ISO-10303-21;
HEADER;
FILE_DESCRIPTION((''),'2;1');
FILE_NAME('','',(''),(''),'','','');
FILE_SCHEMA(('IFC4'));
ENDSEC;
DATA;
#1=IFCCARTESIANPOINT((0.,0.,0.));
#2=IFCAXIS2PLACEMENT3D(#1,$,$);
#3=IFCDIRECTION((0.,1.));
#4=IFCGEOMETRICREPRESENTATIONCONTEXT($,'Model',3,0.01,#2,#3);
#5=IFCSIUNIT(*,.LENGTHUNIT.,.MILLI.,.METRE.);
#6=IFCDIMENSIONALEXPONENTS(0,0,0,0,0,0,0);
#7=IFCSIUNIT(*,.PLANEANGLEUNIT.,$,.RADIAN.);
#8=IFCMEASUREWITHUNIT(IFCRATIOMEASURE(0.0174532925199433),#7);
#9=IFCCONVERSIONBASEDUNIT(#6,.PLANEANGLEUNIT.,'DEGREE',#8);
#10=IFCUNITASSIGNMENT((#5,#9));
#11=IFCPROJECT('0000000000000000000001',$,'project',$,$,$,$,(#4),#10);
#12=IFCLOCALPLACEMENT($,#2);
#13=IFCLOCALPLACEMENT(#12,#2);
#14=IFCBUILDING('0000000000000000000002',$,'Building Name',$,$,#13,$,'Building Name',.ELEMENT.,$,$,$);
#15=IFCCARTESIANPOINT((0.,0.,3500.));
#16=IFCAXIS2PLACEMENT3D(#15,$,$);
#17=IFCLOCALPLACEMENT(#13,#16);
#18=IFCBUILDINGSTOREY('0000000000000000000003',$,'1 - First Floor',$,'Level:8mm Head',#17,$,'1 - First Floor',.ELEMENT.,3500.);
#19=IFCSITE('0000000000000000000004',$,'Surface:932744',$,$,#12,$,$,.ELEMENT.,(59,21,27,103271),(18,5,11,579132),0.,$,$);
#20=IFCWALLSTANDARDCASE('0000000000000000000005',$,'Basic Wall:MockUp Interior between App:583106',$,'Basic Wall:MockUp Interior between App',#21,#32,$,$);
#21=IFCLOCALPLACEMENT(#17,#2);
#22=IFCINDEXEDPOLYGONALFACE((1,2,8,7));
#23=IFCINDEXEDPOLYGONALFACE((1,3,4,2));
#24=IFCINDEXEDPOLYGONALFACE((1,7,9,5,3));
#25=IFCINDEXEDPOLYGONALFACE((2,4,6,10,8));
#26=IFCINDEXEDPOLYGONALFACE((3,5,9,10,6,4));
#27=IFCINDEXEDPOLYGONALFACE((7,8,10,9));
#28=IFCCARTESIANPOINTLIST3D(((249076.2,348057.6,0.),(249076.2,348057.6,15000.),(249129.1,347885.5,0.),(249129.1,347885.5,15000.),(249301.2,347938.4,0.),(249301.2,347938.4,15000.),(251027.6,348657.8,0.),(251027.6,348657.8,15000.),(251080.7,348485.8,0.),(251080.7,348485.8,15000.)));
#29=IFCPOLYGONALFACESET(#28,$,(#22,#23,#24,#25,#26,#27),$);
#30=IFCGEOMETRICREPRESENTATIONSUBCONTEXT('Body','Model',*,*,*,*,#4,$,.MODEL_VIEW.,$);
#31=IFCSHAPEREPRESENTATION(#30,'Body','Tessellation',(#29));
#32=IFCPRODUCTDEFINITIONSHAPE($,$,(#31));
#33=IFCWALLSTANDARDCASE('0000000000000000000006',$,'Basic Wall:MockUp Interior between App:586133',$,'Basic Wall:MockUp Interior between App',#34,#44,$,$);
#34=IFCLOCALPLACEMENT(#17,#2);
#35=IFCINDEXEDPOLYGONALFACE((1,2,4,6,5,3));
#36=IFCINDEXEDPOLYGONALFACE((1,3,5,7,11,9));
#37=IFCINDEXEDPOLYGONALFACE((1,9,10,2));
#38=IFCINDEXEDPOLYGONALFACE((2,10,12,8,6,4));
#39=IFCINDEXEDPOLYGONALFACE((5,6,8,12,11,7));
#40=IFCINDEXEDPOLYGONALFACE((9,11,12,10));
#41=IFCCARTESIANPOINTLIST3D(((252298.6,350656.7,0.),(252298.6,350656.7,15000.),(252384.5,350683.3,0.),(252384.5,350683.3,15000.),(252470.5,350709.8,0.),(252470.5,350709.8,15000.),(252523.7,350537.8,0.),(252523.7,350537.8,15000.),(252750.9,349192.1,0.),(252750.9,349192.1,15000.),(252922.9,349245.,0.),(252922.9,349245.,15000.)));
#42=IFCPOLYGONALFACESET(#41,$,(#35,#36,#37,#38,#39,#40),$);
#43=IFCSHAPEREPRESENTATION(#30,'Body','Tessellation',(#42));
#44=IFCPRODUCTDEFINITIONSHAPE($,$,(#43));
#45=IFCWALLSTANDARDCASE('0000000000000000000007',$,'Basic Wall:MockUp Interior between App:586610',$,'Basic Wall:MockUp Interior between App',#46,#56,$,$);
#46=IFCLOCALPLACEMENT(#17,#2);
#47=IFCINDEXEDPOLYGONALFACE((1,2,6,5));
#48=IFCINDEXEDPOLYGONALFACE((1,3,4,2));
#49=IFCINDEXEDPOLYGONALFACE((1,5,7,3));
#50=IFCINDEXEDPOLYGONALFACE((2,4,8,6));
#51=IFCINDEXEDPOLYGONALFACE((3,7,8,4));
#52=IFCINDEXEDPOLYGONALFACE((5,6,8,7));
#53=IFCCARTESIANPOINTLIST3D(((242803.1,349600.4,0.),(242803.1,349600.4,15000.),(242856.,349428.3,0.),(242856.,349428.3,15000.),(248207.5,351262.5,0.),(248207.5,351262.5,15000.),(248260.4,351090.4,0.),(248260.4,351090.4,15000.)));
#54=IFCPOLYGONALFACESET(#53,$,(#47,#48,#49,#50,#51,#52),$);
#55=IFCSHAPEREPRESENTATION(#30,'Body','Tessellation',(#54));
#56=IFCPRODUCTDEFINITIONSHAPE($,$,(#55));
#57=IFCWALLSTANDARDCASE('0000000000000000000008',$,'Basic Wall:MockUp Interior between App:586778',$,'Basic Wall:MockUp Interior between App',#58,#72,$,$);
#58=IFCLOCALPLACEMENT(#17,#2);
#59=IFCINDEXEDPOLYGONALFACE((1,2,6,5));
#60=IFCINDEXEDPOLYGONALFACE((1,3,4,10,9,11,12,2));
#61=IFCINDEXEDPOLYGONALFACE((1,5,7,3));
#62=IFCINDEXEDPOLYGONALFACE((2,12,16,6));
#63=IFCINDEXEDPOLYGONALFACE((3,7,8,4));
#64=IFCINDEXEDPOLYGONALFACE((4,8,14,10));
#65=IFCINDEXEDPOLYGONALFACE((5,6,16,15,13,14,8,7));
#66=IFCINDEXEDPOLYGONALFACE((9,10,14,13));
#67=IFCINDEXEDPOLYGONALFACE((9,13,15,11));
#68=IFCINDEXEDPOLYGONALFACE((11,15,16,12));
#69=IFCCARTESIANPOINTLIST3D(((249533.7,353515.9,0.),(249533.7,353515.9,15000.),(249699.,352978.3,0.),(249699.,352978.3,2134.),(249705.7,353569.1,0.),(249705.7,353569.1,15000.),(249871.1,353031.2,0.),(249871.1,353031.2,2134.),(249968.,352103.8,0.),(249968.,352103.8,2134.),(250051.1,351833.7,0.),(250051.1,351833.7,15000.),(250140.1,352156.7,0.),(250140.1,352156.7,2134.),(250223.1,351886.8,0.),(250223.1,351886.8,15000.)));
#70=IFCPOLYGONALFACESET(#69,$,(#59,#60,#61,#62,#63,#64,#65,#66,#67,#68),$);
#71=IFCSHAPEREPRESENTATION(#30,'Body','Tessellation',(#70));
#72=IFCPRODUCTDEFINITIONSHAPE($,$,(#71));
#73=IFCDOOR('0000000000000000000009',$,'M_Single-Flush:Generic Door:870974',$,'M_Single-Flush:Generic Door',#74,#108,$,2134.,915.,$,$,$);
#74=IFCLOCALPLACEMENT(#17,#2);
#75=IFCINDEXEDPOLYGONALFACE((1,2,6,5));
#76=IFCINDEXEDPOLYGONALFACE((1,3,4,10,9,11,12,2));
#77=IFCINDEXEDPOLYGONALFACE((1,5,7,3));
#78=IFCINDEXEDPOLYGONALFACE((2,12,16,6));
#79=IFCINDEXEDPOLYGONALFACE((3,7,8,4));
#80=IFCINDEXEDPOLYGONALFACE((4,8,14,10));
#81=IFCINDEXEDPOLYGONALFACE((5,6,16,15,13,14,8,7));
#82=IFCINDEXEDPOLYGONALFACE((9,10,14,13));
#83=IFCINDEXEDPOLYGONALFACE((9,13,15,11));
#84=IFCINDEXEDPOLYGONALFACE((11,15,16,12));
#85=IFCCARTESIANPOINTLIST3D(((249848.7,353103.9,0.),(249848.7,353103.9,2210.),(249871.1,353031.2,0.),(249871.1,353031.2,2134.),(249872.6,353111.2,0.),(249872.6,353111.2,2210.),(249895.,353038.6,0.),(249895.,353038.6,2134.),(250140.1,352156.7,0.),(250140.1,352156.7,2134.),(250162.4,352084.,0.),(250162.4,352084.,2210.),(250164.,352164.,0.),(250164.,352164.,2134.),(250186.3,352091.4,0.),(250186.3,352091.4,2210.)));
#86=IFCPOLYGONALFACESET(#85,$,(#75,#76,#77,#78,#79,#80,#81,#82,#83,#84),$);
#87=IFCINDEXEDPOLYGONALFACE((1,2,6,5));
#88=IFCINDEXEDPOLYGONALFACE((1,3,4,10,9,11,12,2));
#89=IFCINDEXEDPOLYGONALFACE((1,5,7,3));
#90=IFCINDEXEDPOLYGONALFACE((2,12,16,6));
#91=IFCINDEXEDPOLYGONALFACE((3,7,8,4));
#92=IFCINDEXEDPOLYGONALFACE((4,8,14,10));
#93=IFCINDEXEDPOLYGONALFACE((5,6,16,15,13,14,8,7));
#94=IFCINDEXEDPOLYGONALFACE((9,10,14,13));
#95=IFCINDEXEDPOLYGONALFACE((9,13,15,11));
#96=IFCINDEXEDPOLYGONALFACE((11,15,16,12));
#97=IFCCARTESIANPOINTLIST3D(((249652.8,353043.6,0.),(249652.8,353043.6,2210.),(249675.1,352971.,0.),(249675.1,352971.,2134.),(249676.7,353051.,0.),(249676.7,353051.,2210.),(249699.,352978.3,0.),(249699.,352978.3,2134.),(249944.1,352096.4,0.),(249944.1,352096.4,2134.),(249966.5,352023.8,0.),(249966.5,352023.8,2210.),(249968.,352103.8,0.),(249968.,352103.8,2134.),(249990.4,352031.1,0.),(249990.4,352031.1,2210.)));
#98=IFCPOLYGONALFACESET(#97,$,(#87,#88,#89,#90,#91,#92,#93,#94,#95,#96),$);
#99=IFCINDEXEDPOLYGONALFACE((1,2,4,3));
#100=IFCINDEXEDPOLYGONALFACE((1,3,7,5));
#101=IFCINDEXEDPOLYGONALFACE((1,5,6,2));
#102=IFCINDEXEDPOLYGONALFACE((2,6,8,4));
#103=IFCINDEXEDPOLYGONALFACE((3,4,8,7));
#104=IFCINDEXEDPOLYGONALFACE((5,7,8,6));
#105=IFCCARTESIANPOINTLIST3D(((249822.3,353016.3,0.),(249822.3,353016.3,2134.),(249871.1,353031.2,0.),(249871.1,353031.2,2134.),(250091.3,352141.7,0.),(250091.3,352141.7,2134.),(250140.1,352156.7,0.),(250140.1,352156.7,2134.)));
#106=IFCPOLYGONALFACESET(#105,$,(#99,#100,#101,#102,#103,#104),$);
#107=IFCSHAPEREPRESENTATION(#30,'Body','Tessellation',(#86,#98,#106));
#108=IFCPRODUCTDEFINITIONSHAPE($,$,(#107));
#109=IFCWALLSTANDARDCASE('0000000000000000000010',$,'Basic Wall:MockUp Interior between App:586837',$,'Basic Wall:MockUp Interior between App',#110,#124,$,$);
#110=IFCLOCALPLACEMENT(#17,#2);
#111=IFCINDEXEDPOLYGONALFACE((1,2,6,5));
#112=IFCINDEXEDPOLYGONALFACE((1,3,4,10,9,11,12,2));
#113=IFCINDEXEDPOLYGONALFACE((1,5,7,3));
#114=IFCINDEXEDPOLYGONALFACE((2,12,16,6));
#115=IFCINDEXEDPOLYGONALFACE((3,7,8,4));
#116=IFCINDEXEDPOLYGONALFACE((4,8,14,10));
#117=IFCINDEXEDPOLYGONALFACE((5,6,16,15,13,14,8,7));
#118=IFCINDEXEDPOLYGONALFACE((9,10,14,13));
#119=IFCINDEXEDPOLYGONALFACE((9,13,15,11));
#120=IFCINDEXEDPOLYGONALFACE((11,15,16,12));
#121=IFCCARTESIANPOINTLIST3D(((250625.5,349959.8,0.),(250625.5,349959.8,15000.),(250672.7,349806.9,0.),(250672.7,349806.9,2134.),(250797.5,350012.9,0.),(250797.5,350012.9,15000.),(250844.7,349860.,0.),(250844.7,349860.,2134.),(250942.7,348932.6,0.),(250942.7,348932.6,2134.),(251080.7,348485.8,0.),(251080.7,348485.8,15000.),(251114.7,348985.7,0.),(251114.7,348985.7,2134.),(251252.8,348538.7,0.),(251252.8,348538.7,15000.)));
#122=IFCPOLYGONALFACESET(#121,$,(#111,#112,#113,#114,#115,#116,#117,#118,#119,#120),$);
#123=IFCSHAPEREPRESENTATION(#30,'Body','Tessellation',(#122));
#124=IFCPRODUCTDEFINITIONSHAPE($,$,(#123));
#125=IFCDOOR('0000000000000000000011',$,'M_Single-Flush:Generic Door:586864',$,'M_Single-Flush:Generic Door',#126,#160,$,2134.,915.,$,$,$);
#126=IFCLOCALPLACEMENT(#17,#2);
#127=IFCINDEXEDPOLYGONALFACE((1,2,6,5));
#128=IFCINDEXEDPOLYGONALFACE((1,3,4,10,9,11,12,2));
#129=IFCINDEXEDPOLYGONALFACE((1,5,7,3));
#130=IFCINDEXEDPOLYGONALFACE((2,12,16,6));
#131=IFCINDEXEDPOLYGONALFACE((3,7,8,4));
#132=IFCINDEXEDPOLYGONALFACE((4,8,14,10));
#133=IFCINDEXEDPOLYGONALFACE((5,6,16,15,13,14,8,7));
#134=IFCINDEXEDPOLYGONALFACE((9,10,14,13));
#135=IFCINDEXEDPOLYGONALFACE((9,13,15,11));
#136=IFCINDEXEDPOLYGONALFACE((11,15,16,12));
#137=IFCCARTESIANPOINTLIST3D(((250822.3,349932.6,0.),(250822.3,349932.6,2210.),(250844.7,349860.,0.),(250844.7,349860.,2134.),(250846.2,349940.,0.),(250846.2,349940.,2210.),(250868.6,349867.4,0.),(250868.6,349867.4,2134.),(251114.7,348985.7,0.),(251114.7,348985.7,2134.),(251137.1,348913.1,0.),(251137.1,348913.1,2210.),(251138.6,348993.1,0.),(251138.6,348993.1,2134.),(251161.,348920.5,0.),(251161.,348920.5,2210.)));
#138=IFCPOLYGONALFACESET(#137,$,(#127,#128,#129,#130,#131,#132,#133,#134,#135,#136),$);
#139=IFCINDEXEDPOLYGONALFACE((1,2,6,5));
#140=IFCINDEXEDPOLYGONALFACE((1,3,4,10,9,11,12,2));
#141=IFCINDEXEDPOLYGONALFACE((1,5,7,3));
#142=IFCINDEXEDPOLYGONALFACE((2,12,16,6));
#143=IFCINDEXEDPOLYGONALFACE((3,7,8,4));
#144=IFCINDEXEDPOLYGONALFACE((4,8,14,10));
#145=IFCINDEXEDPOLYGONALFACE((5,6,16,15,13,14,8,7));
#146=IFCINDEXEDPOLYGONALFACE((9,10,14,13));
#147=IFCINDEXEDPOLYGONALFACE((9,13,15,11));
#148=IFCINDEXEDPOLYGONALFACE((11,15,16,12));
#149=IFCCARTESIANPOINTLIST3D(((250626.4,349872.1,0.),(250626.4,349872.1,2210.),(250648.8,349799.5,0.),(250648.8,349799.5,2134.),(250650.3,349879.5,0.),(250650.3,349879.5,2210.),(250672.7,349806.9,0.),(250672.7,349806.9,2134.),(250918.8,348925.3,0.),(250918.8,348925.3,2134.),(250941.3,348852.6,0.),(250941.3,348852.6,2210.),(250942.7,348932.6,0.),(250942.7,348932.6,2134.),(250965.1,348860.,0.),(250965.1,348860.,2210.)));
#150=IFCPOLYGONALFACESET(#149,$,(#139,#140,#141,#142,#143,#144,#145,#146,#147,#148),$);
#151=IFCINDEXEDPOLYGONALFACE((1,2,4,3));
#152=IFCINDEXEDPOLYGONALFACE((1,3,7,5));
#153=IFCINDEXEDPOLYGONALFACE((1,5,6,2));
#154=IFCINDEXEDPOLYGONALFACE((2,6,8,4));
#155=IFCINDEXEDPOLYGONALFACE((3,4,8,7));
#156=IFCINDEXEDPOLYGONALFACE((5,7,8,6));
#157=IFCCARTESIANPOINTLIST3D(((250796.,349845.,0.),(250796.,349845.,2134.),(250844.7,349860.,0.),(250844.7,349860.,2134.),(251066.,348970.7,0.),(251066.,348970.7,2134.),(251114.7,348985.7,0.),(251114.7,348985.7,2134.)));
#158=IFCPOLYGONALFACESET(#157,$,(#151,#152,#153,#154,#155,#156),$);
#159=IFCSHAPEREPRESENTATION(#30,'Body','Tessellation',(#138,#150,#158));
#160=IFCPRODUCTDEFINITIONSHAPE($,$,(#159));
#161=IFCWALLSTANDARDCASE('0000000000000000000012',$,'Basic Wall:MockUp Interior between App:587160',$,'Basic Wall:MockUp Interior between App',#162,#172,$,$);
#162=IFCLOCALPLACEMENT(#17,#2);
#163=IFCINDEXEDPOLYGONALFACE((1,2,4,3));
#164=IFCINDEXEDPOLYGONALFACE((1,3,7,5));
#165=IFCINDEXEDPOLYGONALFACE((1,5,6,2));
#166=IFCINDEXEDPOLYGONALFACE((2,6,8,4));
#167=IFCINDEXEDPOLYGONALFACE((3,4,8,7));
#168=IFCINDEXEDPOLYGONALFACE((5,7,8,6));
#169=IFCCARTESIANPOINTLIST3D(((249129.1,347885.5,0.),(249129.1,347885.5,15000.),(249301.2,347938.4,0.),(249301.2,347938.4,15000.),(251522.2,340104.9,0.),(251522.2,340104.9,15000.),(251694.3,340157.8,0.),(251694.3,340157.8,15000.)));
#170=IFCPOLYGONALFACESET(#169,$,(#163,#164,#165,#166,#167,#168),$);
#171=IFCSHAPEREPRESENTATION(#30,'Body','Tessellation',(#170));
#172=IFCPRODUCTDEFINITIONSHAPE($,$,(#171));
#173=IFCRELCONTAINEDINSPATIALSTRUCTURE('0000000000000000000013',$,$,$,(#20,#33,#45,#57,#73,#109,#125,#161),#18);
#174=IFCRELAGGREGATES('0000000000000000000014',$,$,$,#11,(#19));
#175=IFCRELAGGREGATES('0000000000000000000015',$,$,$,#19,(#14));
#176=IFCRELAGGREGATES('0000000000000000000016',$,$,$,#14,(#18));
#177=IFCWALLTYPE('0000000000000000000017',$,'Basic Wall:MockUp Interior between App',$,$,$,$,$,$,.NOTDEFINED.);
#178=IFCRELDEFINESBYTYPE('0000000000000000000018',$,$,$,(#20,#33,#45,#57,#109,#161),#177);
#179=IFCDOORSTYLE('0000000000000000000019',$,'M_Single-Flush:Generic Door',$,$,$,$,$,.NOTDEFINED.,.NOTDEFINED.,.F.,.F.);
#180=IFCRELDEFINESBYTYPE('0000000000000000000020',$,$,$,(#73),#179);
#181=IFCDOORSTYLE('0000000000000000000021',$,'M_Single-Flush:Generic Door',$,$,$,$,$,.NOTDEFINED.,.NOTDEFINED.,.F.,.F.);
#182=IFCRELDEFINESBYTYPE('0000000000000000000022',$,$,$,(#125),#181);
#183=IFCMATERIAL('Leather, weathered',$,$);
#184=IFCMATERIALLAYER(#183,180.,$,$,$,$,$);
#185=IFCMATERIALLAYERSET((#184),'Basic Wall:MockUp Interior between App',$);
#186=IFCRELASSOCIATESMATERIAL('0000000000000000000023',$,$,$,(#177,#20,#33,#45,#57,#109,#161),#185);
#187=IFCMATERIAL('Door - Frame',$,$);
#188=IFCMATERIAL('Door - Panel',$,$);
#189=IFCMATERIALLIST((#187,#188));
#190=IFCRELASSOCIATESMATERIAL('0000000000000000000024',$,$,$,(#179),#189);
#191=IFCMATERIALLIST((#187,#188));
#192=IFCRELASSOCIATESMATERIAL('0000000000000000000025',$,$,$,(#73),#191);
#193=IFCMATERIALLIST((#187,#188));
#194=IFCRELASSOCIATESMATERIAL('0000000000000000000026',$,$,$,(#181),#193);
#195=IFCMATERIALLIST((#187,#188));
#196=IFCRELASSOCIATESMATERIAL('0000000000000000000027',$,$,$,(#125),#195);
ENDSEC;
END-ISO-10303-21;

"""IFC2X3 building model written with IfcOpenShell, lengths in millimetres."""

from ifc_helpers import new_model, entity, si_unit, converted_unit, direction, frame, frame_2d, origin, place, context, subcontext, project, spatial, polyline, rectangle, outline, extrude, source, transform, mapped, material, material_list, layer, layer_set, layer_usage, type_object, type_shapes, element, fill, save


model = new_model("IFC2X3")

# Units and contexts
model_context = context("Model", 3, precision=0.01, world=origin(), true_north=direction((0.0, 1.0)))
body_context = subcontext(model_context, "Body", "Model", "MODEL_VIEW")
ifc_project = project(units=[si_unit("LENGTHUNIT", "METRE", prefix="MILLI"), converted_unit("PLANEANGLEUNIT", "DEGREE", entity("IfcRatioMeasure", 0.0174532925199433), si_unit("PLANEANGLEUNIT", "RADIAN"), dimensions=[0, 0, 0, 0, 0, 0, 0])], contexts=[model_context])

# Site, building, storey
site_placement = place(None, origin())
site = spatial("IfcSite", under=ifc_project, at=site_placement, Name="Surface:932744", CompositionType="ELEMENT", RefLatitude=(59, 21, 27, 103271), RefLongitude=(18, 5, 11, 579132), RefElevation=0.0)
building_placement = place(site_placement, origin())
building = spatial("IfcBuilding", under=site, at=building_placement, Name="Building Name", LongName="Building Name", CompositionType="ELEMENT")
storey_placement = place(building_placement, frame((0.0, 0.0, 3500.0)))
storey = spatial("IfcBuildingStorey", under=building, at=storey_placement, Name="1 - First Floor", ObjectType="Level:8mm Head", LongName="1 - First Floor", CompositionType="ELEMENT", Elevation=3500.0)

# Walls
ifc_material_1 = material(Name="Leather, weathered")
ifc_layer_1 = layer(ifc_material_1, 180.0)
ifc_layer_set_1 = layer_set([ifc_layer_1], Name="Basic Wall:MockUp Interior between App")
ifc_layer_usage_1 = layer_usage(ifc_layer_set_1, "AXIS2", "NEGATIVE", 90.0)
wall_type_1 = type_object("IfcWallType", Name="Basic Wall:MockUp Interior between App", PredefinedType="NOTDEFINED", material=ifc_layer_set_1)
wall_1_placement = place(storey_placement, frame((249102.6, 347971.5, 0.0), z_axis=(0.0, 0.0, 1.0), x_axis=(0.955811, 0.29398, 0.0)))
element("IfcWallStandardCase", 1, at=wall_1_placement, inside=storey, type_object=wall_type_1, material=ifc_layer_usage_1, Name="Basic Wall:MockUp Interior between App:583106", ObjectType="Basic Wall:MockUp Interior between App", context=body_context, shape_type="SweptSolid", body=[
    extrude(outline(polyline([(0.0, 90.0), (0.0, -90.0), (180.0, -90.0), (2041.8, -90.0), (2041.6, 90.0), (0.0, 90.0)])), origin(), (0.0, 0.0, 1.0), 15000.0),
])
ifc_layer_usage_2 = layer_usage(ifc_layer_set_1, "AXIS2", "NEGATIVE", 90.0)
wall_2_placement = place(storey_placement, frame((252384.5, 350683.3, 0.0), z_axis=(0.0, 0.0, 1.0), x_axis=(0.29508, -0.955473, 0.0)))
element("IfcWallStandardCase", 2, at=wall_2_placement, inside=storey, type_object=wall_type_1, material=ifc_layer_usage_2, Name="Basic Wall:MockUp Interior between App:586133", ObjectType="Basic Wall:MockUp Interior between App", context=body_context, shape_type="SweptSolid", body=[
    extrude(outline(polyline([(1532.8, -90.0), (1533.1, 90.0), (180.0, 90.0), (0.0, 90.0), (0.0, 0.0), (0.0, -90.0), (1532.8, -90.0)])), origin(), (0.0, 0.0, 1.0), 15000.0),
])
ifc_layer_usage_3 = layer_usage(ifc_layer_set_1, "AXIS2", "NEGATIVE", 90.0)
wall_3_placement = place(storey_placement, frame((248234.0, 351176.5, 0.0), z_axis=(0.0, 0.0, 1.0), x_axis=(-0.955818, -0.293958, 0.0)))
element("IfcWallStandardCase", 3, at=wall_3_placement, inside=storey, type_object=wall_type_1, material=ifc_layer_usage_3, Name="Basic Wall:MockUp Interior between App:586610", ObjectType="Basic Wall:MockUp Interior between App", context=body_context, shape_type="SweptSolid", body=[
    extrude(rectangle(XDim=5654.2, YDim=180.0, at=frame_2d((2827.1, 0.0), x_axis=(-1.0, 0.0))), origin(), (0.0, 0.0, 1.0), 15000.0),
])

# Walls, openings, doors
ifc_layer_usage_4 = layer_usage(ifc_layer_set_1, "AXIS2", "NEGATIVE", 90.0)
wall_4_placement = place(storey_placement, frame((250137.1, 351860.2, 0.0), z_axis=(0.0, 0.0, 1.0), x_axis=(-0.293958, 0.955818, 0.0)))
wall_4 = element("IfcWallStandardCase", 4, at=wall_4_placement, inside=storey, type_object=wall_type_1, material=ifc_layer_usage_4, Name="Basic Wall:MockUp Interior between App:586778", ObjectType="Basic Wall:MockUp Interior between App", context=body_context, shape_type="SweptSolid", body=[
    extrude(outline(polyline([(0.2, -90.0), (1760.2, -90.0), (1760.0, 90.0), (0.0, 90.0), (0.2, -90.0)])), origin(), (0.0, 0.0, 1.0), 15000.0),
])
opening_1_placement = place(wall_4_placement, frame((1197.5, 90.0, 0.0)))
opening_1 = element("IfcOpeningElement", 5, at=opening_1_placement, cuts=wall_4, ObjectType="Opening", context=body_context, shape_type="SweptSolid", body=[
    extrude(rectangle(XDim=915.0, YDim=2134.0, at=frame_2d((1067.0, 457.5), x_axis=(0.0, 1.0))), frame((0.0, 0.0, 0.0), z_axis=(0.0, -1.0, 0.0), x_axis=(0.0, 0.0, 1.0)), (0.0, 0.0, 1.0), 180.0),
])
ifc_material_2 = material(Name="Door - Frame")
ifc_material_3 = material(Name="Door - Panel")
ifc_material_list_1 = material_list([ifc_material_2, ifc_material_3])
ifc_material_list_2 = material_list([ifc_material_2, ifc_material_3])
door_style_1 = type_object("IfcDoorStyle", Name="M_Single-Flush:Generic Door", ConstructionType="NOTDEFINED", OperationType="NOTDEFINED", ParameterTakesPrecedence=False, Sizeable=False, material=ifc_material_list_2)
shared_shape_1 = source(origin(), body_context, "Body", "SweptSolid", [
    extrude(outline(polyline([(-533.5, -1124.0), (533.5, -1124.0), (533.5, 1086.0), (457.5, 1086.0), (457.5, -1048.0), (-457.5, -1048.0), (-457.5, 1086.0), (-533.5, 1086.0), (-533.5, -1124.0)])), frame((457.5, 180.0, 1086.0), z_axis=(0.0, 1.0, 0.0), x_axis=(1.0, 0.0, 0.0)), (0.0, 0.0, 1.0), 25.0),
    extrude(outline(polyline([(-1124.0, -533.5), (1086.0, -533.5), (1086.0, -457.5), (-1048.0, -457.5), (-1048.0, 457.5), (1086.0, 457.5), (1086.0, 533.5), (-1124.0, 533.5), (-1124.0, -533.5)])), frame((457.5, -25.0, 1086.0), z_axis=(0.0, 1.0, 0.0), x_axis=(0.0, 0.0, -1.0)), (0.0, 0.0, 1.0), 25.0),
    extrude(rectangle(XDim=51.0, YDim=915.0, at=frame_2d((0.0, 0.0), x_axis=(1.0, 0.0))), frame((457.5, 154.5, 0.0), z_axis=(0.0, 0.0, 1.0), x_axis=(0.0, 1.0, 0.0)), (0.0, 0.0, 1.0), 2134.0),
])
type_shapes(door_style_1, [shared_shape_1])
door_1_placement = place(opening_1_placement, frame((0.0, 0.0, 0.0), z_axis=(0.0, 0.0, 1.0), x_axis=(-1.0, 0.0, 0.0)))
door_1 = element("IfcDoor", 6, at=door_1_placement, inside=storey, type_object=door_style_1, material=ifc_material_list_1, Name="M_Single-Flush:Generic Door:870974", ObjectType="M_Single-Flush:Generic Door", OverallHeight=2134.0, OverallWidth=915.0, context=body_context, shape_type="MappedRepresentation", body=[
    mapped(shared_shape_1, transform((0.0, 0.0, 0.0), scale=1.0)),
])
fill(opening_1, door_1)
ifc_layer_usage_5 = layer_usage(ifc_layer_set_1, "AXIS2", "NEGATIVE", 90.0)
wall_5_placement = place(storey_placement, frame((250711.5, 349986.3, 0.0), z_axis=(0.0, 0.0, 1.0), x_axis=(0.29508, -0.955473, 0.0)))
wall_5 = element("IfcWallStandardCase", 7, at=wall_5_placement, inside=storey, type_object=wall_type_1, material=ifc_layer_usage_5, Name="Basic Wall:MockUp Interior between App:586837", ObjectType="Basic Wall:MockUp Interior between App", context=body_context, shape_type="SweptSolid", body=[
    extrude(outline(polyline([(0.0, -90.0), (1362.7, -90.0), (1542.7, -90.0), (1542.9, 90.0), (1538.8, 90.0), (1358.8, 90.0), (0.0, 90.0), (0.0, -88.2), (0.0, -90.0)])), origin(), (0.0, 0.0, 1.0), 15000.0),
])
opening_2_placement = place(wall_5_placement, frame((160.0, -90.0, 0.0)))
opening_2 = element("IfcOpeningElement", 8, at=opening_2_placement, cuts=wall_5, ObjectType="Opening", context=body_context, shape_type="SweptSolid", body=[
    extrude(rectangle(XDim=915.0, YDim=2134.0, at=frame_2d((1067.0, 457.5), x_axis=(0.0, -1.0))), frame((0.0, 0.0, 0.0), z_axis=(0.0, 1.0, 0.0), x_axis=(0.0, 0.0, 1.0)), (0.0, 0.0, 1.0), 180.0),
])
ifc_material_list_3 = material_list([ifc_material_2, ifc_material_3])
ifc_material_list_4 = material_list([ifc_material_2, ifc_material_3])
door_style_2 = type_object("IfcDoorStyle", Name="M_Single-Flush:Generic Door", ConstructionType="NOTDEFINED", OperationType="NOTDEFINED", ParameterTakesPrecedence=False, Sizeable=False, material=ifc_material_list_4)
shared_shape_2 = source(origin(), body_context, "Body", "SweptSolid", [
    extrude(outline(polyline([(-533.5, -1124.0), (533.5, -1124.0), (533.5, 1086.0), (457.5, 1086.0), (457.5, -1048.0), (-457.5, -1048.0), (-457.5, 1086.0), (-533.5, 1086.0), (-533.5, -1124.0)])), frame((457.5, 205.0, 1086.0), z_axis=(0.0, -1.0, 0.0), x_axis=(-1.0, 0.0, 0.0)), (0.0, 0.0, 1.0), 25.0),
    extrude(outline(polyline([(-1124.0, -533.5), (1086.0, -533.5), (1086.0, -457.5), (-1048.0, -457.5), (-1048.0, 457.5), (1086.0, 457.5), (1086.0, 533.5), (-1124.0, 533.5), (-1124.0, -533.5)])), frame((457.5, 0.0, 1086.0), z_axis=(0.0, -1.0, 0.0), x_axis=(0.0, 0.0, -1.0)), (0.0, 0.0, 1.0), 25.0),
    extrude(rectangle(XDim=915.0, YDim=51.0, at=frame_2d((0.0, 0.0), x_axis=(1.0, 0.0))), frame((457.5, 154.5, 0.0)), (0.0, 0.0, 1.0), 2134.0),
])
type_shapes(door_style_2, [shared_shape_2])
door_2_placement = place(opening_2_placement, origin())
door_2 = element("IfcDoor", 9, at=door_2_placement, inside=storey, type_object=door_style_2, material=ifc_material_list_3, Name="M_Single-Flush:Generic Door:586864", ObjectType="M_Single-Flush:Generic Door", OverallHeight=2134.0, OverallWidth=915.0, context=body_context, shape_type="MappedRepresentation", body=[
    mapped(shared_shape_2, transform((0.0, 0.0, 0.0), scale=1.0)),
])
fill(opening_2, door_2)

# Wall
ifc_layer_usage_6 = layer_usage(ifc_layer_set_1, "AXIS2", "NEGATIVE", 90.0)
wall_6_placement = place(storey_placement, frame((249215.1, 347912.0, 0.0), z_axis=(0.0, 0.0, 1.0), x_axis=(0.29398, -0.955811, 0.0)))
element("IfcWallStandardCase", 10, at=wall_6_placement, inside=storey, type_object=wall_type_1, material=ifc_layer_usage_6, Name="Basic Wall:MockUp Interior between App:587160", ObjectType="Basic Wall:MockUp Interior between App", context=body_context, shape_type="SweptSolid", body=[
    extrude(rectangle(XDim=8140.4, YDim=180.0, at=frame_2d((4070.2, 0.0), x_axis=(-1.0, 0.0))), origin(), (0.0, 0.0, 1.0), 15000.0),
])

save(model, "model.ifc")
